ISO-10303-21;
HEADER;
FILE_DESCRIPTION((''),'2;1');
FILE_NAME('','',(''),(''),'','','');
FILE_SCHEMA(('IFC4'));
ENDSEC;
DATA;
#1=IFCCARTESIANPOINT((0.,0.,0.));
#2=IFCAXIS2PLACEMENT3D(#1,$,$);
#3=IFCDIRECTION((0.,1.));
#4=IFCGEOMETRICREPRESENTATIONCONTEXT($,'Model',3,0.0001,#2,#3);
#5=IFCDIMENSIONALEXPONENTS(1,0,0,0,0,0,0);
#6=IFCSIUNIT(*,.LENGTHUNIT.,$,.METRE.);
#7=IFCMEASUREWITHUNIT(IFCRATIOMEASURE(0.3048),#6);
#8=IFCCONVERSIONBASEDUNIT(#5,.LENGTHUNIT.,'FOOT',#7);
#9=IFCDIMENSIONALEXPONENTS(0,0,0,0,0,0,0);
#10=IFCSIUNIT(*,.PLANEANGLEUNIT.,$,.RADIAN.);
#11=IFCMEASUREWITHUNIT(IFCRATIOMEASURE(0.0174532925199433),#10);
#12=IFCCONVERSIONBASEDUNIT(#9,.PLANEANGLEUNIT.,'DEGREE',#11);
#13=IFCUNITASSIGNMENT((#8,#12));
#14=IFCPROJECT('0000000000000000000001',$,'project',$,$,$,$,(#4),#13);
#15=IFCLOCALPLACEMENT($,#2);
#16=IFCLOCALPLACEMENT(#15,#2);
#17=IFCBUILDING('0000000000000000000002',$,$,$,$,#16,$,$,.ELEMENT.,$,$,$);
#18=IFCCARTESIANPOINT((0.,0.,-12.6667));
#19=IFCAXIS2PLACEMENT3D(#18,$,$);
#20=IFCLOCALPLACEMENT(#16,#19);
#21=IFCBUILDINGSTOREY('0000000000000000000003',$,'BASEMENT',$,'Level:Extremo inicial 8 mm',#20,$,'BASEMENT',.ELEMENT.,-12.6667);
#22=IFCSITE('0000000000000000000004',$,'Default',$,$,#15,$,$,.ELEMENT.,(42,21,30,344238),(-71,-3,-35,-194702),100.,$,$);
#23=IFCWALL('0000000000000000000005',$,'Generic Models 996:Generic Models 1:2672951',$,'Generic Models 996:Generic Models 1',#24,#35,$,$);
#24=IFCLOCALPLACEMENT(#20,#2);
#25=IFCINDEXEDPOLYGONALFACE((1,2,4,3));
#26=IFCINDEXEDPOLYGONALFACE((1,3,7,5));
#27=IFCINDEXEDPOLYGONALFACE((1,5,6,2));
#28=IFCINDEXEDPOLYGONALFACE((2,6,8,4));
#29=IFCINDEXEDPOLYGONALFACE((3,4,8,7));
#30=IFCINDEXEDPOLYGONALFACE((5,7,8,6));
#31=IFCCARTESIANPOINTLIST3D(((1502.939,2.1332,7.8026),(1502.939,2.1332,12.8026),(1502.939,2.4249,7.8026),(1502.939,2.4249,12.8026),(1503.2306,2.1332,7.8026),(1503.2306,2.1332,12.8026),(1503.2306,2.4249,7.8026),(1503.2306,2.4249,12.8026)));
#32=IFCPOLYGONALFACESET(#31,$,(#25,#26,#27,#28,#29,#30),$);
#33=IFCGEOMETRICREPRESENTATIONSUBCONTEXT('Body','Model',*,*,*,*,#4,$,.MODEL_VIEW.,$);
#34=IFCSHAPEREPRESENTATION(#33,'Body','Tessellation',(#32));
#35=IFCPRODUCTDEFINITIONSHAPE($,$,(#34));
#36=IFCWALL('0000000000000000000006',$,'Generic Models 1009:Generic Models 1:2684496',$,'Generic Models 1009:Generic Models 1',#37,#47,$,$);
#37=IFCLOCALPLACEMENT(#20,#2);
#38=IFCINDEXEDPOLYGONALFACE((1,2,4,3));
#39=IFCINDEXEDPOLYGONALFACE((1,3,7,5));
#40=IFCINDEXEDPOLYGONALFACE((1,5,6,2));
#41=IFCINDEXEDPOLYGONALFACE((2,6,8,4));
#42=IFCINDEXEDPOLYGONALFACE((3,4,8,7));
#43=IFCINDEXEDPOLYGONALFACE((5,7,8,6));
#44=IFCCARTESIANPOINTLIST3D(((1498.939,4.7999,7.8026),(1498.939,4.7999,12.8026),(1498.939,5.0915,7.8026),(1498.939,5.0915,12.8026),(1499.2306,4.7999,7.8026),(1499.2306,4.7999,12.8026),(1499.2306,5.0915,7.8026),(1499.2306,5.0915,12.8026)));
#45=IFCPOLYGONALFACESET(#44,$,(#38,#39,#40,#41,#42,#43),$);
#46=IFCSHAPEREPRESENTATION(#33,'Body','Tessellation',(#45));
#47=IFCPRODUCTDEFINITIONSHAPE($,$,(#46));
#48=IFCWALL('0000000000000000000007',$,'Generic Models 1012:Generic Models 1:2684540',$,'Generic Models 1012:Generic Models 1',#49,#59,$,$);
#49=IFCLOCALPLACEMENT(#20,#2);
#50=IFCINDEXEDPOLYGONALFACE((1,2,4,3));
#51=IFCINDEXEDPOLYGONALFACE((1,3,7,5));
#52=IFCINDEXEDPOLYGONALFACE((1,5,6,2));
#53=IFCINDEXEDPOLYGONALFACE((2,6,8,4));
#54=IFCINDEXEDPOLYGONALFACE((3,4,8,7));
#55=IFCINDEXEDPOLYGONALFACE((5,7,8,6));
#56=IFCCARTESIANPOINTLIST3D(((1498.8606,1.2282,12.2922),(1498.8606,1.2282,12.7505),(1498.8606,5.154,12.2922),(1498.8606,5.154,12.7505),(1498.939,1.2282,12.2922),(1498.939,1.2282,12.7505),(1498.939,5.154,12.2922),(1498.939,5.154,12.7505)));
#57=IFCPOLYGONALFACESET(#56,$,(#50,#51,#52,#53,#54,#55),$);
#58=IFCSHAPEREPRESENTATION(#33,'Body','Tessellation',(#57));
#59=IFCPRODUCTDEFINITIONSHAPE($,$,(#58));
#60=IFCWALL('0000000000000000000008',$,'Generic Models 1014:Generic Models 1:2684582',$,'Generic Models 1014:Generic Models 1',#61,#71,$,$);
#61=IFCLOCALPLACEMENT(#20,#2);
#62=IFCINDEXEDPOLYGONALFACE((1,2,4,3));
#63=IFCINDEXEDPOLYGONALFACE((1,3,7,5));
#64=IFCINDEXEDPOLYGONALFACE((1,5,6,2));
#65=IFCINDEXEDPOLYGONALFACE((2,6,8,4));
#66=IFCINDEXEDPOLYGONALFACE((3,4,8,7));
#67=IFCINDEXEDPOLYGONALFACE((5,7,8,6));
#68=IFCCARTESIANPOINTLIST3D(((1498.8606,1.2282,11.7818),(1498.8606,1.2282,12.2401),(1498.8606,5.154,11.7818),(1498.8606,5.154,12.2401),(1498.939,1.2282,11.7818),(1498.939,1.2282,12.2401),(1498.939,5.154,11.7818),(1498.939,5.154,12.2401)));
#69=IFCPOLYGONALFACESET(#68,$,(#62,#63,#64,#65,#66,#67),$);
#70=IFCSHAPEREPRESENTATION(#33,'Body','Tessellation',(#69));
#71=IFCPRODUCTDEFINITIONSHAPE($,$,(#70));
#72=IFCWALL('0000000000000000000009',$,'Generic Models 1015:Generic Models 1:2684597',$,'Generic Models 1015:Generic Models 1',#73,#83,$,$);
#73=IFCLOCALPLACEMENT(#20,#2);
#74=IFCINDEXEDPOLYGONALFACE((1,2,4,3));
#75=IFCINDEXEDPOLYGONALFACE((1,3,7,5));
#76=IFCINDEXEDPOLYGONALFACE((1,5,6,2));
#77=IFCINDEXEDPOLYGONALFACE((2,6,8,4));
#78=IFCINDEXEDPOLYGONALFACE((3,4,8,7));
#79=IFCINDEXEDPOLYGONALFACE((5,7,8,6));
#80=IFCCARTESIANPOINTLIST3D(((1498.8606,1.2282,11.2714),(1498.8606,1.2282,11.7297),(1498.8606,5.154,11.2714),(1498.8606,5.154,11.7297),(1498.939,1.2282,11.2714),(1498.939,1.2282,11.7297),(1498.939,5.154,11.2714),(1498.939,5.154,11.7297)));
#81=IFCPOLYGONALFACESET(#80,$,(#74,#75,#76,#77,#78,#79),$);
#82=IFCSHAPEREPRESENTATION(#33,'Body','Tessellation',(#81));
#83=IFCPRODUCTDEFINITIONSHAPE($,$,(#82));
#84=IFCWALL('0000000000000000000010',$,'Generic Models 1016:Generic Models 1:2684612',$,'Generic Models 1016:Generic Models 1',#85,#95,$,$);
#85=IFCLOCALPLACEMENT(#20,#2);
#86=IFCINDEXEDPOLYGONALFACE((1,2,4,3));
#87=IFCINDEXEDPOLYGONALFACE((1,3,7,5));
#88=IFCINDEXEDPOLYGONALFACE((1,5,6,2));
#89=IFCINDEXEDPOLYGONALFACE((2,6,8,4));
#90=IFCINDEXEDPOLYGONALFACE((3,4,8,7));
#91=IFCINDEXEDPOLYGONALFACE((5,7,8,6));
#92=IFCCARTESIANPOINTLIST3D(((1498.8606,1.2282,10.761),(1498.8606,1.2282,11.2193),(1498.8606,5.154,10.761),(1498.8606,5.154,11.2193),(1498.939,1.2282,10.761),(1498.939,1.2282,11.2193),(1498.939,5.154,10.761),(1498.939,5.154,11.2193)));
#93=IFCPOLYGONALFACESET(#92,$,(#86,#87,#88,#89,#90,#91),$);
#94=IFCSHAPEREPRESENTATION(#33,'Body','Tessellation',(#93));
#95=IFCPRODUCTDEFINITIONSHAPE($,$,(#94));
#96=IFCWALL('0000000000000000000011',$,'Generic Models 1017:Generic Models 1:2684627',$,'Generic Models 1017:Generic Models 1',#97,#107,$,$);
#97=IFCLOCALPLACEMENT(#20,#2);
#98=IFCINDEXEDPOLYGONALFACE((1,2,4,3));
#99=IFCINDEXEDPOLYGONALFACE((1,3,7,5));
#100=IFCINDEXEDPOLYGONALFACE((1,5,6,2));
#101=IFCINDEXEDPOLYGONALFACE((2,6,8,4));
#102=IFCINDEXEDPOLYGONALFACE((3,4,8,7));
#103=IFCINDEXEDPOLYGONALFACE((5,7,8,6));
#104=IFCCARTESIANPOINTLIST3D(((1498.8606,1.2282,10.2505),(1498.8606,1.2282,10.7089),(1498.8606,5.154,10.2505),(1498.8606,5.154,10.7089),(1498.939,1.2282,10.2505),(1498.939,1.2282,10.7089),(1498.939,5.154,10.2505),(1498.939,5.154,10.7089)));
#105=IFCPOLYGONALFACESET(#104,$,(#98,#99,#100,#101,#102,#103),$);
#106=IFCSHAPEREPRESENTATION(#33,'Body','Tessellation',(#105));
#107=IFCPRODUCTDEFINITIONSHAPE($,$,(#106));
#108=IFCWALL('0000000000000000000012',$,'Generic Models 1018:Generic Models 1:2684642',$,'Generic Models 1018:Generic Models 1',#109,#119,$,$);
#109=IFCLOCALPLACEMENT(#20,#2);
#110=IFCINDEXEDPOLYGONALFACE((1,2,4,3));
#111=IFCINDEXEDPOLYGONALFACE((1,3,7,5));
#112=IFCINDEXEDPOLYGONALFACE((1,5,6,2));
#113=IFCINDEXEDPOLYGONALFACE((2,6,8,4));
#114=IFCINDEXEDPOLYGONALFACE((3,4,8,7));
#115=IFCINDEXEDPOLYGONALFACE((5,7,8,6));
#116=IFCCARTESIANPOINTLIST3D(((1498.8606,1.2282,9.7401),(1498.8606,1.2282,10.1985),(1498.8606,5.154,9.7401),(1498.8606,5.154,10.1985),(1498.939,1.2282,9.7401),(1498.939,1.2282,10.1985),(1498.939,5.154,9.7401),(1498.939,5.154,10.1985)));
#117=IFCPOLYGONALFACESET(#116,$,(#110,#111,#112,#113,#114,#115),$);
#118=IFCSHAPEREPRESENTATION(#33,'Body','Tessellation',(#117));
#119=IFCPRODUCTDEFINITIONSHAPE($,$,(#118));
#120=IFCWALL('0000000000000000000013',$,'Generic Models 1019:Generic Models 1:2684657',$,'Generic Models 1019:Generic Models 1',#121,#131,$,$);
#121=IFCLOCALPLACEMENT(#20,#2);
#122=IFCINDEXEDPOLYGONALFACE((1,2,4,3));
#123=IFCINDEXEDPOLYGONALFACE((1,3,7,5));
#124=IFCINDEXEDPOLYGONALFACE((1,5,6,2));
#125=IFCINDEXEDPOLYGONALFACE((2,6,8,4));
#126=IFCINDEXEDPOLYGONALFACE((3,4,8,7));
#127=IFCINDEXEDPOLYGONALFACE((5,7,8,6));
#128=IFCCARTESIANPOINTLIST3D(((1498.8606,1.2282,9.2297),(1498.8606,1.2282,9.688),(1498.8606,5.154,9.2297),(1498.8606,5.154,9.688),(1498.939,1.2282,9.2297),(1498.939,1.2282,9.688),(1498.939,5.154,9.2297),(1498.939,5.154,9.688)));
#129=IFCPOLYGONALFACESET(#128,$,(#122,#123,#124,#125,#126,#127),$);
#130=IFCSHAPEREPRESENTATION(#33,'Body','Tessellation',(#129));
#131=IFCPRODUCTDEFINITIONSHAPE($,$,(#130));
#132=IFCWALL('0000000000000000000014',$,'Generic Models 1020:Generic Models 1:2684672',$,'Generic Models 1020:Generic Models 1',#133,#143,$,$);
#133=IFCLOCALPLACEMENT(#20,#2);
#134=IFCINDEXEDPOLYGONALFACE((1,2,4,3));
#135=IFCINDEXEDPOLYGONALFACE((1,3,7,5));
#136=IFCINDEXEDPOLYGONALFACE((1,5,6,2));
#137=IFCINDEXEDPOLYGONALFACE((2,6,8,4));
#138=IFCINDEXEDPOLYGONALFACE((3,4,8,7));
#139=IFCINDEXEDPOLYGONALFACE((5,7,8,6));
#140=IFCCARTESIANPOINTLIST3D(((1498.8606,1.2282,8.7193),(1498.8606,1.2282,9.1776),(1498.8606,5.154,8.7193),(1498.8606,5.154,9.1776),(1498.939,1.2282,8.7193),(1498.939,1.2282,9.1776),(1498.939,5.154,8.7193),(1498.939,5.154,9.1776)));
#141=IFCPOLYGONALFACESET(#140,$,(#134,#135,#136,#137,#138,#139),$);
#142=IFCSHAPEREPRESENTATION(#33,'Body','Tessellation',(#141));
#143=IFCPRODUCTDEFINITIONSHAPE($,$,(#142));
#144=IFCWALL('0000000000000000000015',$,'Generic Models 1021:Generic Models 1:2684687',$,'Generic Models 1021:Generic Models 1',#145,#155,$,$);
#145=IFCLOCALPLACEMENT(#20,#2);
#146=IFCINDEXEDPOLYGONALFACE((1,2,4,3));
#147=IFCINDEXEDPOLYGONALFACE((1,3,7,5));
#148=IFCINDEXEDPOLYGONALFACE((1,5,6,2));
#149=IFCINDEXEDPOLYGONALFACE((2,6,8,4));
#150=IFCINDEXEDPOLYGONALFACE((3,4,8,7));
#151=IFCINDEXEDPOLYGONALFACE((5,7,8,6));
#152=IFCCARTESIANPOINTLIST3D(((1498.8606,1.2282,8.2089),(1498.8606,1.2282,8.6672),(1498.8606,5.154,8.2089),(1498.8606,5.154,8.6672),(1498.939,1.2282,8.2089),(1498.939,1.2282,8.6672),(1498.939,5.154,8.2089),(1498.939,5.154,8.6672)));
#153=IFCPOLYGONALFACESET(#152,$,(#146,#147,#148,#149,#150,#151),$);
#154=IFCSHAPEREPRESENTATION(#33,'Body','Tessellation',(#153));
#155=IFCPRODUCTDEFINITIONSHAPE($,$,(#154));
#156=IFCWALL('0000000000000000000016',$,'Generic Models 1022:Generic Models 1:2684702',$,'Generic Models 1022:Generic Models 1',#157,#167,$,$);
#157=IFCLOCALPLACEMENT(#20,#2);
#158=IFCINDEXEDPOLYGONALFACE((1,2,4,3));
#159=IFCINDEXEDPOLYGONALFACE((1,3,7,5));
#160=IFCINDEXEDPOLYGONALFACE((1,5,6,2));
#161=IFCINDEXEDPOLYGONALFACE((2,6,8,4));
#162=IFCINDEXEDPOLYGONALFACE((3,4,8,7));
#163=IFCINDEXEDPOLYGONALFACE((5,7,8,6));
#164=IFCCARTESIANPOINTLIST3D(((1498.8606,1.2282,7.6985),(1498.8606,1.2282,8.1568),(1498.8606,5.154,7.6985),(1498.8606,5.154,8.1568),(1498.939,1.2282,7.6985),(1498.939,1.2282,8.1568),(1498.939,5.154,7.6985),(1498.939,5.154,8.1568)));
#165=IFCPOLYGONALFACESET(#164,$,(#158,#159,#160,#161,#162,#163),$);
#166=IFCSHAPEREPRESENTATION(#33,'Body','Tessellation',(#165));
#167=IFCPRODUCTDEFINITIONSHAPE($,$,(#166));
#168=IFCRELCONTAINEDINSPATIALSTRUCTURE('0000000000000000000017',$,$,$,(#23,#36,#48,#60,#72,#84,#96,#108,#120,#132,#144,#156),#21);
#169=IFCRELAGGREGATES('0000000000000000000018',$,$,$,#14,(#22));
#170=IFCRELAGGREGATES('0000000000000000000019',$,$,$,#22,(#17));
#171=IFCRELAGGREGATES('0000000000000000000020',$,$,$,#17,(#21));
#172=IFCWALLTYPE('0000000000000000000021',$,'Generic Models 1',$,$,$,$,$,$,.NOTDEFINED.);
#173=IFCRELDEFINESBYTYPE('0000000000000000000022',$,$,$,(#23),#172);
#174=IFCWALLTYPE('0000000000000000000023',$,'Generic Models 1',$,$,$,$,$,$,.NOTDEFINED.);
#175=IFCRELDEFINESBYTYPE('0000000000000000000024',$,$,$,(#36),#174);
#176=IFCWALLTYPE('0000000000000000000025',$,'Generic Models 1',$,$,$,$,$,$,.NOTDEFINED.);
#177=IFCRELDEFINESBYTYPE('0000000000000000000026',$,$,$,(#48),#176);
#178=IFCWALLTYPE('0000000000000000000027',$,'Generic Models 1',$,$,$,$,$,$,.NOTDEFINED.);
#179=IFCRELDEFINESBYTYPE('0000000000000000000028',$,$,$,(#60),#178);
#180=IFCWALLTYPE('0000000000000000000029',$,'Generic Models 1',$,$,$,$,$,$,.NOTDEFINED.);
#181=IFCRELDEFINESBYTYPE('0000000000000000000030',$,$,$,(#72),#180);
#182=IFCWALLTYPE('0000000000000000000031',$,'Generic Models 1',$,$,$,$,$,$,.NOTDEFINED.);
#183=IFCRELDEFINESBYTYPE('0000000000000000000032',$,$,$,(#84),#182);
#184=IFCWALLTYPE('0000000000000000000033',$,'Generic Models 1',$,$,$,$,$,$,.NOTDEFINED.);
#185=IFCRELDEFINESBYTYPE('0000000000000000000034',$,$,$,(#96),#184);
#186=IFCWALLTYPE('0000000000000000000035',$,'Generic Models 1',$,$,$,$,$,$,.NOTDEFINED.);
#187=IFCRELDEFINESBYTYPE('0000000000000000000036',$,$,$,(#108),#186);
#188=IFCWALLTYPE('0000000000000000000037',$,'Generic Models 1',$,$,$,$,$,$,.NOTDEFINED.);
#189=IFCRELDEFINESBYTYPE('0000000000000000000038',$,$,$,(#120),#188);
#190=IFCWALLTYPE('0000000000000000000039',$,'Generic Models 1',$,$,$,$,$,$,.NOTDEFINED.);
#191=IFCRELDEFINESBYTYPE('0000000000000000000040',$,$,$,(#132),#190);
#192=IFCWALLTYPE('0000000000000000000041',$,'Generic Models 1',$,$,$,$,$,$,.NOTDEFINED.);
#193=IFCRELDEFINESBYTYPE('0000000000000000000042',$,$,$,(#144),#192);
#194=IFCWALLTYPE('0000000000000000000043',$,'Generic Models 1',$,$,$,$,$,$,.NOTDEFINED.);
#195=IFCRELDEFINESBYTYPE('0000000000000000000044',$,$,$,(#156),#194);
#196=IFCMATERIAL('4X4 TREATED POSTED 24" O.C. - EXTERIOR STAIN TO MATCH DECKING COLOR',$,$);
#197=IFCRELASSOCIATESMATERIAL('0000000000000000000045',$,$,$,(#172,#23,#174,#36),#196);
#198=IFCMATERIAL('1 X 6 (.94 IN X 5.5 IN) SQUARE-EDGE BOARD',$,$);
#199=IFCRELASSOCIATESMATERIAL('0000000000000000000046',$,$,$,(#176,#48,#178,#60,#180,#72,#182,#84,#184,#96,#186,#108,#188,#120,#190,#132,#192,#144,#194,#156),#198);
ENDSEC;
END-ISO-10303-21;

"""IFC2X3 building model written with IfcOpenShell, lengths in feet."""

from ifc_helpers import new_model, entity, si_unit, converted_unit, direction, frame, frame_2d, origin, place, context, subcontext, project, spatial, rectangle, extrude, material, type_object, element, save


model = new_model("IFC2X3")

# Units and contexts
model_context = context("Model", 3, precision=0.0001, world=origin(), true_north=direction((0.0, 1.0)))
body_context = subcontext(model_context, "Body", "Model", "MODEL_VIEW")
ifc_project = project(units=[converted_unit("LENGTHUNIT", "FOOT", entity("IfcRatioMeasure", 0.3048), si_unit("LENGTHUNIT", "METRE"), dimensions=[1, 0, 0, 0, 0, 0, 0]), converted_unit("PLANEANGLEUNIT", "DEGREE", entity("IfcRatioMeasure", 0.0174532925199433), si_unit("PLANEANGLEUNIT", "RADIAN"), dimensions=[0, 0, 0, 0, 0, 0, 0])], contexts=[model_context])

# Site, building, storey
site_placement = place(None, origin())
site = spatial("IfcSite", under=ifc_project, at=site_placement, Name="Default", CompositionType="ELEMENT", RefLatitude=(42, 21, 30, 344238), RefLongitude=(-71, -3, -35, -194702), RefElevation=100.0)
building_placement = place(site_placement, origin())
building = spatial("IfcBuilding", under=site, at=building_placement, CompositionType="ELEMENT")
storey_placement = place(building_placement, frame((0.0, 0.0, -12.6667)))
storey = spatial("IfcBuildingStorey", under=building, at=storey_placement, Name="BASEMENT", ObjectType="Level:Extremo inicial 8 mm", LongName="BASEMENT", CompositionType="ELEMENT", Elevation=-12.6667)

# Walls
ifc_material_1 = material(Name="4X4 TREATED POSTED 24\" O.C. - EXTERIOR STAIN TO MATCH DECKING COLOR")
ifc_material_2 = material(Name="1 X 6 (.94 IN X 5.5 IN) SQUARE-EDGE BOARD")
wall_type_1 = type_object("IfcWallType", Name="Generic Models 1", PredefinedType="NOTDEFINED", material=ifc_material_1)
wall_1_placement = place(storey_placement, frame((1502.939, 2.1332, 7.8026)))
element("IfcWall", 1, at=wall_1_placement, inside=storey, type_object=wall_type_1, material=ifc_material_1, Name="Generic Models 996:Generic Models 1:2672951", ObjectType="Generic Models 996:Generic Models 1", context=body_context, shape_type="SweptSolid", body=[
    extrude(rectangle(XDim=0.2917, YDim=0.2917, at=frame_2d((0.0, 0.0), x_axis=(1.0, 0.0))), frame((0.1458, 0.1458, 0.0), z_axis=(0.0, 0.0, 1.0), x_axis=(0.0, 1.0, 0.0)), (0.0, 0.0, 1.0), 5.0),
])
wall_type_2 = type_object("IfcWallType", Name="Generic Models 1", PredefinedType="NOTDEFINED", material=ifc_material_1)
wall_2_placement = place(storey_placement, frame((1498.939, 4.7999, 7.8026)))
element("IfcWall", 2, at=wall_2_placement, inside=storey, type_object=wall_type_2, material=ifc_material_1, Name="Generic Models 1009:Generic Models 1:2684496", ObjectType="Generic Models 1009:Generic Models 1", context=body_context, shape_type="SweptSolid", body=[
    extrude(rectangle(XDim=0.2917, YDim=0.2917, at=frame_2d((0.0, 0.0), x_axis=(1.0, 0.0))), frame((0.1458, 0.1458, 0.0), z_axis=(0.0, 0.0, 1.0), x_axis=(0.0, 1.0, 0.0)), (0.0, 0.0, 1.0), 5.0),
])
wall_type_3 = type_object("IfcWallType", Name="Generic Models 1", PredefinedType="NOTDEFINED", material=ifc_material_2)
wall_3_placement = place(storey_placement, frame((1498.8606, 1.2282, 12.2922), z_axis=(0.0, 0.0, 1.0), x_axis=(0.0, 1.0, 0.0)))
element("IfcWall", 3, at=wall_3_placement, inside=storey, type_object=wall_type_3, material=ifc_material_2, Name="Generic Models 1012:Generic Models 1:2684540", ObjectType="Generic Models 1012:Generic Models 1", context=body_context, shape_type="SweptSolid", body=[
    extrude(rectangle(XDim=3.9258, YDim=0.0783, at=frame_2d((0.0, 0.0), x_axis=(1.0, 0.0))), frame((1.9629, -0.0392, 0.0)), (0.0, 0.0, 1.0), 0.4583),
])
wall_type_4 = type_object("IfcWallType", Name="Generic Models 1", PredefinedType="NOTDEFINED", material=ifc_material_2)
wall_4_placement = place(storey_placement, frame((1498.8606, 1.2282, 11.7818), z_axis=(0.0, 0.0, 1.0), x_axis=(0.0, 1.0, 0.0)))
element("IfcWall", 4, at=wall_4_placement, inside=storey, type_object=wall_type_4, material=ifc_material_2, Name="Generic Models 1014:Generic Models 1:2684582", ObjectType="Generic Models 1014:Generic Models 1", context=body_context, shape_type="SweptSolid", body=[
    extrude(rectangle(XDim=3.9258, YDim=0.0783, at=frame_2d((0.0, 0.0), x_axis=(1.0, 0.0))), frame((1.9629, -0.0392, 0.0)), (0.0, 0.0, 1.0), 0.4583),
])
wall_type_5 = type_object("IfcWallType", Name="Generic Models 1", PredefinedType="NOTDEFINED", material=ifc_material_2)
wall_5_placement = place(storey_placement, frame((1498.8606, 1.2282, 11.2714), z_axis=(0.0, 0.0, 1.0), x_axis=(0.0, 1.0, 0.0)))
element("IfcWall", 5, at=wall_5_placement, inside=storey, type_object=wall_type_5, material=ifc_material_2, Name="Generic Models 1015:Generic Models 1:2684597", ObjectType="Generic Models 1015:Generic Models 1", context=body_context, shape_type="SweptSolid", body=[
    extrude(rectangle(XDim=3.9258, YDim=0.0783, at=frame_2d((0.0, 0.0), x_axis=(1.0, 0.0))), frame((1.9629, -0.0392, 0.0)), (0.0, 0.0, 1.0), 0.4583),
])
wall_type_6 = type_object("IfcWallType", Name="Generic Models 1", PredefinedType="NOTDEFINED", material=ifc_material_2)
wall_6_placement = place(storey_placement, frame((1498.8606, 1.2282, 10.761), z_axis=(0.0, 0.0, 1.0), x_axis=(0.0, 1.0, 0.0)))
element("IfcWall", 6, at=wall_6_placement, inside=storey, type_object=wall_type_6, material=ifc_material_2, Name="Generic Models 1016:Generic Models 1:2684612", ObjectType="Generic Models 1016:Generic Models 1", context=body_context, shape_type="SweptSolid", body=[
    extrude(rectangle(XDim=3.9258, YDim=0.0783, at=frame_2d((0.0, 0.0), x_axis=(1.0, 0.0))), frame((1.9629, -0.0392, 0.0)), (0.0, 0.0, 1.0), 0.4583),
])
wall_type_7 = type_object("IfcWallType", Name="Generic Models 1", PredefinedType="NOTDEFINED", material=ifc_material_2)
wall_7_placement = place(storey_placement, frame((1498.8606, 1.2282, 10.2505), z_axis=(0.0, 0.0, 1.0), x_axis=(0.0, 1.0, 0.0)))
element("IfcWall", 7, at=wall_7_placement, inside=storey, type_object=wall_type_7, material=ifc_material_2, Name="Generic Models 1017:Generic Models 1:2684627", ObjectType="Generic Models 1017:Generic Models 1", context=body_context, shape_type="SweptSolid", body=[
    extrude(rectangle(XDim=3.9258, YDim=0.0783, at=frame_2d((0.0, 0.0), x_axis=(1.0, 0.0))), frame((1.9629, -0.0392, 0.0)), (0.0, 0.0, 1.0), 0.4583),
])
wall_type_8 = type_object("IfcWallType", Name="Generic Models 1", PredefinedType="NOTDEFINED", material=ifc_material_2)
wall_8_placement = place(storey_placement, frame((1498.8606, 1.2282, 9.7401), z_axis=(0.0, 0.0, 1.0), x_axis=(0.0, 1.0, 0.0)))
element("IfcWall", 8, at=wall_8_placement, inside=storey, type_object=wall_type_8, material=ifc_material_2, Name="Generic Models 1018:Generic Models 1:2684642", ObjectType="Generic Models 1018:Generic Models 1", context=body_context, shape_type="SweptSolid", body=[
    extrude(rectangle(XDim=3.9258, YDim=0.0783, at=frame_2d((0.0, 0.0), x_axis=(1.0, 0.0))), frame((1.9629, -0.0392, 0.0)), (0.0, 0.0, 1.0), 0.4583),
])
wall_type_9 = type_object("IfcWallType", Name="Generic Models 1", PredefinedType="NOTDEFINED", material=ifc_material_2)
wall_9_placement = place(storey_placement, frame((1498.8606, 1.2282, 9.2297), z_axis=(0.0, 0.0, 1.0), x_axis=(0.0, 1.0, 0.0)))
element("IfcWall", 9, at=wall_9_placement, inside=storey, type_object=wall_type_9, material=ifc_material_2, Name="Generic Models 1019:Generic Models 1:2684657", ObjectType="Generic Models 1019:Generic Models 1", context=body_context, shape_type="SweptSolid", body=[
    extrude(rectangle(XDim=3.9258, YDim=0.0783, at=frame_2d((0.0, 0.0), x_axis=(1.0, 0.0))), frame((1.9629, -0.0392, 0.0)), (0.0, 0.0, 1.0), 0.4583),
])
wall_type_10 = type_object("IfcWallType", Name="Generic Models 1", PredefinedType="NOTDEFINED", material=ifc_material_2)
wall_10_placement = place(storey_placement, frame((1498.8606, 1.2282, 8.7193), z_axis=(0.0, 0.0, 1.0), x_axis=(0.0, 1.0, 0.0)))
element("IfcWall", 10, at=wall_10_placement, inside=storey, type_object=wall_type_10, material=ifc_material_2, Name="Generic Models 1020:Generic Models 1:2684672", ObjectType="Generic Models 1020:Generic Models 1", context=body_context, shape_type="SweptSolid", body=[
    extrude(rectangle(XDim=3.9258, YDim=0.0783, at=frame_2d((0.0, 0.0), x_axis=(1.0, 0.0))), frame((1.9629, -0.0392, 0.0)), (0.0, 0.0, 1.0), 0.4583),
])
wall_type_11 = type_object("IfcWallType", Name="Generic Models 1", PredefinedType="NOTDEFINED", material=ifc_material_2)
wall_11_placement = place(storey_placement, frame((1498.8606, 1.2282, 8.2089), z_axis=(0.0, 0.0, 1.0), x_axis=(0.0, 1.0, 0.0)))
element("IfcWall", 11, at=wall_11_placement, inside=storey, type_object=wall_type_11, material=ifc_material_2, Name="Generic Models 1021:Generic Models 1:2684687", ObjectType="Generic Models 1021:Generic Models 1", context=body_context, shape_type="SweptSolid", body=[
    extrude(rectangle(XDim=3.9258, YDim=0.0783, at=frame_2d((0.0, 0.0), x_axis=(1.0, 0.0))), frame((1.9629, -0.0392, 0.0)), (0.0, 0.0, 1.0), 0.4583),
])
wall_type_12 = type_object("IfcWallType", Name="Generic Models 1", PredefinedType="NOTDEFINED", material=ifc_material_2)
wall_12_placement = place(storey_placement, frame((1498.8606, 1.2282, 7.6985), z_axis=(0.0, 0.0, 1.0), x_axis=(0.0, 1.0, 0.0)))
element("IfcWall", 12, at=wall_12_placement, inside=storey, type_object=wall_type_12, material=ifc_material_2, Name="Generic Models 1022:Generic Models 1:2684702", ObjectType="Generic Models 1022:Generic Models 1", context=body_context, shape_type="SweptSolid", body=[
    extrude(rectangle(XDim=3.9258, YDim=0.0783, at=frame_2d((0.0, 0.0), x_axis=(1.0, 0.0))), frame((1.9629, -0.0392, 0.0)), (0.0, 0.0, 1.0), 0.4583),
])

save(model, "model.ifc")
